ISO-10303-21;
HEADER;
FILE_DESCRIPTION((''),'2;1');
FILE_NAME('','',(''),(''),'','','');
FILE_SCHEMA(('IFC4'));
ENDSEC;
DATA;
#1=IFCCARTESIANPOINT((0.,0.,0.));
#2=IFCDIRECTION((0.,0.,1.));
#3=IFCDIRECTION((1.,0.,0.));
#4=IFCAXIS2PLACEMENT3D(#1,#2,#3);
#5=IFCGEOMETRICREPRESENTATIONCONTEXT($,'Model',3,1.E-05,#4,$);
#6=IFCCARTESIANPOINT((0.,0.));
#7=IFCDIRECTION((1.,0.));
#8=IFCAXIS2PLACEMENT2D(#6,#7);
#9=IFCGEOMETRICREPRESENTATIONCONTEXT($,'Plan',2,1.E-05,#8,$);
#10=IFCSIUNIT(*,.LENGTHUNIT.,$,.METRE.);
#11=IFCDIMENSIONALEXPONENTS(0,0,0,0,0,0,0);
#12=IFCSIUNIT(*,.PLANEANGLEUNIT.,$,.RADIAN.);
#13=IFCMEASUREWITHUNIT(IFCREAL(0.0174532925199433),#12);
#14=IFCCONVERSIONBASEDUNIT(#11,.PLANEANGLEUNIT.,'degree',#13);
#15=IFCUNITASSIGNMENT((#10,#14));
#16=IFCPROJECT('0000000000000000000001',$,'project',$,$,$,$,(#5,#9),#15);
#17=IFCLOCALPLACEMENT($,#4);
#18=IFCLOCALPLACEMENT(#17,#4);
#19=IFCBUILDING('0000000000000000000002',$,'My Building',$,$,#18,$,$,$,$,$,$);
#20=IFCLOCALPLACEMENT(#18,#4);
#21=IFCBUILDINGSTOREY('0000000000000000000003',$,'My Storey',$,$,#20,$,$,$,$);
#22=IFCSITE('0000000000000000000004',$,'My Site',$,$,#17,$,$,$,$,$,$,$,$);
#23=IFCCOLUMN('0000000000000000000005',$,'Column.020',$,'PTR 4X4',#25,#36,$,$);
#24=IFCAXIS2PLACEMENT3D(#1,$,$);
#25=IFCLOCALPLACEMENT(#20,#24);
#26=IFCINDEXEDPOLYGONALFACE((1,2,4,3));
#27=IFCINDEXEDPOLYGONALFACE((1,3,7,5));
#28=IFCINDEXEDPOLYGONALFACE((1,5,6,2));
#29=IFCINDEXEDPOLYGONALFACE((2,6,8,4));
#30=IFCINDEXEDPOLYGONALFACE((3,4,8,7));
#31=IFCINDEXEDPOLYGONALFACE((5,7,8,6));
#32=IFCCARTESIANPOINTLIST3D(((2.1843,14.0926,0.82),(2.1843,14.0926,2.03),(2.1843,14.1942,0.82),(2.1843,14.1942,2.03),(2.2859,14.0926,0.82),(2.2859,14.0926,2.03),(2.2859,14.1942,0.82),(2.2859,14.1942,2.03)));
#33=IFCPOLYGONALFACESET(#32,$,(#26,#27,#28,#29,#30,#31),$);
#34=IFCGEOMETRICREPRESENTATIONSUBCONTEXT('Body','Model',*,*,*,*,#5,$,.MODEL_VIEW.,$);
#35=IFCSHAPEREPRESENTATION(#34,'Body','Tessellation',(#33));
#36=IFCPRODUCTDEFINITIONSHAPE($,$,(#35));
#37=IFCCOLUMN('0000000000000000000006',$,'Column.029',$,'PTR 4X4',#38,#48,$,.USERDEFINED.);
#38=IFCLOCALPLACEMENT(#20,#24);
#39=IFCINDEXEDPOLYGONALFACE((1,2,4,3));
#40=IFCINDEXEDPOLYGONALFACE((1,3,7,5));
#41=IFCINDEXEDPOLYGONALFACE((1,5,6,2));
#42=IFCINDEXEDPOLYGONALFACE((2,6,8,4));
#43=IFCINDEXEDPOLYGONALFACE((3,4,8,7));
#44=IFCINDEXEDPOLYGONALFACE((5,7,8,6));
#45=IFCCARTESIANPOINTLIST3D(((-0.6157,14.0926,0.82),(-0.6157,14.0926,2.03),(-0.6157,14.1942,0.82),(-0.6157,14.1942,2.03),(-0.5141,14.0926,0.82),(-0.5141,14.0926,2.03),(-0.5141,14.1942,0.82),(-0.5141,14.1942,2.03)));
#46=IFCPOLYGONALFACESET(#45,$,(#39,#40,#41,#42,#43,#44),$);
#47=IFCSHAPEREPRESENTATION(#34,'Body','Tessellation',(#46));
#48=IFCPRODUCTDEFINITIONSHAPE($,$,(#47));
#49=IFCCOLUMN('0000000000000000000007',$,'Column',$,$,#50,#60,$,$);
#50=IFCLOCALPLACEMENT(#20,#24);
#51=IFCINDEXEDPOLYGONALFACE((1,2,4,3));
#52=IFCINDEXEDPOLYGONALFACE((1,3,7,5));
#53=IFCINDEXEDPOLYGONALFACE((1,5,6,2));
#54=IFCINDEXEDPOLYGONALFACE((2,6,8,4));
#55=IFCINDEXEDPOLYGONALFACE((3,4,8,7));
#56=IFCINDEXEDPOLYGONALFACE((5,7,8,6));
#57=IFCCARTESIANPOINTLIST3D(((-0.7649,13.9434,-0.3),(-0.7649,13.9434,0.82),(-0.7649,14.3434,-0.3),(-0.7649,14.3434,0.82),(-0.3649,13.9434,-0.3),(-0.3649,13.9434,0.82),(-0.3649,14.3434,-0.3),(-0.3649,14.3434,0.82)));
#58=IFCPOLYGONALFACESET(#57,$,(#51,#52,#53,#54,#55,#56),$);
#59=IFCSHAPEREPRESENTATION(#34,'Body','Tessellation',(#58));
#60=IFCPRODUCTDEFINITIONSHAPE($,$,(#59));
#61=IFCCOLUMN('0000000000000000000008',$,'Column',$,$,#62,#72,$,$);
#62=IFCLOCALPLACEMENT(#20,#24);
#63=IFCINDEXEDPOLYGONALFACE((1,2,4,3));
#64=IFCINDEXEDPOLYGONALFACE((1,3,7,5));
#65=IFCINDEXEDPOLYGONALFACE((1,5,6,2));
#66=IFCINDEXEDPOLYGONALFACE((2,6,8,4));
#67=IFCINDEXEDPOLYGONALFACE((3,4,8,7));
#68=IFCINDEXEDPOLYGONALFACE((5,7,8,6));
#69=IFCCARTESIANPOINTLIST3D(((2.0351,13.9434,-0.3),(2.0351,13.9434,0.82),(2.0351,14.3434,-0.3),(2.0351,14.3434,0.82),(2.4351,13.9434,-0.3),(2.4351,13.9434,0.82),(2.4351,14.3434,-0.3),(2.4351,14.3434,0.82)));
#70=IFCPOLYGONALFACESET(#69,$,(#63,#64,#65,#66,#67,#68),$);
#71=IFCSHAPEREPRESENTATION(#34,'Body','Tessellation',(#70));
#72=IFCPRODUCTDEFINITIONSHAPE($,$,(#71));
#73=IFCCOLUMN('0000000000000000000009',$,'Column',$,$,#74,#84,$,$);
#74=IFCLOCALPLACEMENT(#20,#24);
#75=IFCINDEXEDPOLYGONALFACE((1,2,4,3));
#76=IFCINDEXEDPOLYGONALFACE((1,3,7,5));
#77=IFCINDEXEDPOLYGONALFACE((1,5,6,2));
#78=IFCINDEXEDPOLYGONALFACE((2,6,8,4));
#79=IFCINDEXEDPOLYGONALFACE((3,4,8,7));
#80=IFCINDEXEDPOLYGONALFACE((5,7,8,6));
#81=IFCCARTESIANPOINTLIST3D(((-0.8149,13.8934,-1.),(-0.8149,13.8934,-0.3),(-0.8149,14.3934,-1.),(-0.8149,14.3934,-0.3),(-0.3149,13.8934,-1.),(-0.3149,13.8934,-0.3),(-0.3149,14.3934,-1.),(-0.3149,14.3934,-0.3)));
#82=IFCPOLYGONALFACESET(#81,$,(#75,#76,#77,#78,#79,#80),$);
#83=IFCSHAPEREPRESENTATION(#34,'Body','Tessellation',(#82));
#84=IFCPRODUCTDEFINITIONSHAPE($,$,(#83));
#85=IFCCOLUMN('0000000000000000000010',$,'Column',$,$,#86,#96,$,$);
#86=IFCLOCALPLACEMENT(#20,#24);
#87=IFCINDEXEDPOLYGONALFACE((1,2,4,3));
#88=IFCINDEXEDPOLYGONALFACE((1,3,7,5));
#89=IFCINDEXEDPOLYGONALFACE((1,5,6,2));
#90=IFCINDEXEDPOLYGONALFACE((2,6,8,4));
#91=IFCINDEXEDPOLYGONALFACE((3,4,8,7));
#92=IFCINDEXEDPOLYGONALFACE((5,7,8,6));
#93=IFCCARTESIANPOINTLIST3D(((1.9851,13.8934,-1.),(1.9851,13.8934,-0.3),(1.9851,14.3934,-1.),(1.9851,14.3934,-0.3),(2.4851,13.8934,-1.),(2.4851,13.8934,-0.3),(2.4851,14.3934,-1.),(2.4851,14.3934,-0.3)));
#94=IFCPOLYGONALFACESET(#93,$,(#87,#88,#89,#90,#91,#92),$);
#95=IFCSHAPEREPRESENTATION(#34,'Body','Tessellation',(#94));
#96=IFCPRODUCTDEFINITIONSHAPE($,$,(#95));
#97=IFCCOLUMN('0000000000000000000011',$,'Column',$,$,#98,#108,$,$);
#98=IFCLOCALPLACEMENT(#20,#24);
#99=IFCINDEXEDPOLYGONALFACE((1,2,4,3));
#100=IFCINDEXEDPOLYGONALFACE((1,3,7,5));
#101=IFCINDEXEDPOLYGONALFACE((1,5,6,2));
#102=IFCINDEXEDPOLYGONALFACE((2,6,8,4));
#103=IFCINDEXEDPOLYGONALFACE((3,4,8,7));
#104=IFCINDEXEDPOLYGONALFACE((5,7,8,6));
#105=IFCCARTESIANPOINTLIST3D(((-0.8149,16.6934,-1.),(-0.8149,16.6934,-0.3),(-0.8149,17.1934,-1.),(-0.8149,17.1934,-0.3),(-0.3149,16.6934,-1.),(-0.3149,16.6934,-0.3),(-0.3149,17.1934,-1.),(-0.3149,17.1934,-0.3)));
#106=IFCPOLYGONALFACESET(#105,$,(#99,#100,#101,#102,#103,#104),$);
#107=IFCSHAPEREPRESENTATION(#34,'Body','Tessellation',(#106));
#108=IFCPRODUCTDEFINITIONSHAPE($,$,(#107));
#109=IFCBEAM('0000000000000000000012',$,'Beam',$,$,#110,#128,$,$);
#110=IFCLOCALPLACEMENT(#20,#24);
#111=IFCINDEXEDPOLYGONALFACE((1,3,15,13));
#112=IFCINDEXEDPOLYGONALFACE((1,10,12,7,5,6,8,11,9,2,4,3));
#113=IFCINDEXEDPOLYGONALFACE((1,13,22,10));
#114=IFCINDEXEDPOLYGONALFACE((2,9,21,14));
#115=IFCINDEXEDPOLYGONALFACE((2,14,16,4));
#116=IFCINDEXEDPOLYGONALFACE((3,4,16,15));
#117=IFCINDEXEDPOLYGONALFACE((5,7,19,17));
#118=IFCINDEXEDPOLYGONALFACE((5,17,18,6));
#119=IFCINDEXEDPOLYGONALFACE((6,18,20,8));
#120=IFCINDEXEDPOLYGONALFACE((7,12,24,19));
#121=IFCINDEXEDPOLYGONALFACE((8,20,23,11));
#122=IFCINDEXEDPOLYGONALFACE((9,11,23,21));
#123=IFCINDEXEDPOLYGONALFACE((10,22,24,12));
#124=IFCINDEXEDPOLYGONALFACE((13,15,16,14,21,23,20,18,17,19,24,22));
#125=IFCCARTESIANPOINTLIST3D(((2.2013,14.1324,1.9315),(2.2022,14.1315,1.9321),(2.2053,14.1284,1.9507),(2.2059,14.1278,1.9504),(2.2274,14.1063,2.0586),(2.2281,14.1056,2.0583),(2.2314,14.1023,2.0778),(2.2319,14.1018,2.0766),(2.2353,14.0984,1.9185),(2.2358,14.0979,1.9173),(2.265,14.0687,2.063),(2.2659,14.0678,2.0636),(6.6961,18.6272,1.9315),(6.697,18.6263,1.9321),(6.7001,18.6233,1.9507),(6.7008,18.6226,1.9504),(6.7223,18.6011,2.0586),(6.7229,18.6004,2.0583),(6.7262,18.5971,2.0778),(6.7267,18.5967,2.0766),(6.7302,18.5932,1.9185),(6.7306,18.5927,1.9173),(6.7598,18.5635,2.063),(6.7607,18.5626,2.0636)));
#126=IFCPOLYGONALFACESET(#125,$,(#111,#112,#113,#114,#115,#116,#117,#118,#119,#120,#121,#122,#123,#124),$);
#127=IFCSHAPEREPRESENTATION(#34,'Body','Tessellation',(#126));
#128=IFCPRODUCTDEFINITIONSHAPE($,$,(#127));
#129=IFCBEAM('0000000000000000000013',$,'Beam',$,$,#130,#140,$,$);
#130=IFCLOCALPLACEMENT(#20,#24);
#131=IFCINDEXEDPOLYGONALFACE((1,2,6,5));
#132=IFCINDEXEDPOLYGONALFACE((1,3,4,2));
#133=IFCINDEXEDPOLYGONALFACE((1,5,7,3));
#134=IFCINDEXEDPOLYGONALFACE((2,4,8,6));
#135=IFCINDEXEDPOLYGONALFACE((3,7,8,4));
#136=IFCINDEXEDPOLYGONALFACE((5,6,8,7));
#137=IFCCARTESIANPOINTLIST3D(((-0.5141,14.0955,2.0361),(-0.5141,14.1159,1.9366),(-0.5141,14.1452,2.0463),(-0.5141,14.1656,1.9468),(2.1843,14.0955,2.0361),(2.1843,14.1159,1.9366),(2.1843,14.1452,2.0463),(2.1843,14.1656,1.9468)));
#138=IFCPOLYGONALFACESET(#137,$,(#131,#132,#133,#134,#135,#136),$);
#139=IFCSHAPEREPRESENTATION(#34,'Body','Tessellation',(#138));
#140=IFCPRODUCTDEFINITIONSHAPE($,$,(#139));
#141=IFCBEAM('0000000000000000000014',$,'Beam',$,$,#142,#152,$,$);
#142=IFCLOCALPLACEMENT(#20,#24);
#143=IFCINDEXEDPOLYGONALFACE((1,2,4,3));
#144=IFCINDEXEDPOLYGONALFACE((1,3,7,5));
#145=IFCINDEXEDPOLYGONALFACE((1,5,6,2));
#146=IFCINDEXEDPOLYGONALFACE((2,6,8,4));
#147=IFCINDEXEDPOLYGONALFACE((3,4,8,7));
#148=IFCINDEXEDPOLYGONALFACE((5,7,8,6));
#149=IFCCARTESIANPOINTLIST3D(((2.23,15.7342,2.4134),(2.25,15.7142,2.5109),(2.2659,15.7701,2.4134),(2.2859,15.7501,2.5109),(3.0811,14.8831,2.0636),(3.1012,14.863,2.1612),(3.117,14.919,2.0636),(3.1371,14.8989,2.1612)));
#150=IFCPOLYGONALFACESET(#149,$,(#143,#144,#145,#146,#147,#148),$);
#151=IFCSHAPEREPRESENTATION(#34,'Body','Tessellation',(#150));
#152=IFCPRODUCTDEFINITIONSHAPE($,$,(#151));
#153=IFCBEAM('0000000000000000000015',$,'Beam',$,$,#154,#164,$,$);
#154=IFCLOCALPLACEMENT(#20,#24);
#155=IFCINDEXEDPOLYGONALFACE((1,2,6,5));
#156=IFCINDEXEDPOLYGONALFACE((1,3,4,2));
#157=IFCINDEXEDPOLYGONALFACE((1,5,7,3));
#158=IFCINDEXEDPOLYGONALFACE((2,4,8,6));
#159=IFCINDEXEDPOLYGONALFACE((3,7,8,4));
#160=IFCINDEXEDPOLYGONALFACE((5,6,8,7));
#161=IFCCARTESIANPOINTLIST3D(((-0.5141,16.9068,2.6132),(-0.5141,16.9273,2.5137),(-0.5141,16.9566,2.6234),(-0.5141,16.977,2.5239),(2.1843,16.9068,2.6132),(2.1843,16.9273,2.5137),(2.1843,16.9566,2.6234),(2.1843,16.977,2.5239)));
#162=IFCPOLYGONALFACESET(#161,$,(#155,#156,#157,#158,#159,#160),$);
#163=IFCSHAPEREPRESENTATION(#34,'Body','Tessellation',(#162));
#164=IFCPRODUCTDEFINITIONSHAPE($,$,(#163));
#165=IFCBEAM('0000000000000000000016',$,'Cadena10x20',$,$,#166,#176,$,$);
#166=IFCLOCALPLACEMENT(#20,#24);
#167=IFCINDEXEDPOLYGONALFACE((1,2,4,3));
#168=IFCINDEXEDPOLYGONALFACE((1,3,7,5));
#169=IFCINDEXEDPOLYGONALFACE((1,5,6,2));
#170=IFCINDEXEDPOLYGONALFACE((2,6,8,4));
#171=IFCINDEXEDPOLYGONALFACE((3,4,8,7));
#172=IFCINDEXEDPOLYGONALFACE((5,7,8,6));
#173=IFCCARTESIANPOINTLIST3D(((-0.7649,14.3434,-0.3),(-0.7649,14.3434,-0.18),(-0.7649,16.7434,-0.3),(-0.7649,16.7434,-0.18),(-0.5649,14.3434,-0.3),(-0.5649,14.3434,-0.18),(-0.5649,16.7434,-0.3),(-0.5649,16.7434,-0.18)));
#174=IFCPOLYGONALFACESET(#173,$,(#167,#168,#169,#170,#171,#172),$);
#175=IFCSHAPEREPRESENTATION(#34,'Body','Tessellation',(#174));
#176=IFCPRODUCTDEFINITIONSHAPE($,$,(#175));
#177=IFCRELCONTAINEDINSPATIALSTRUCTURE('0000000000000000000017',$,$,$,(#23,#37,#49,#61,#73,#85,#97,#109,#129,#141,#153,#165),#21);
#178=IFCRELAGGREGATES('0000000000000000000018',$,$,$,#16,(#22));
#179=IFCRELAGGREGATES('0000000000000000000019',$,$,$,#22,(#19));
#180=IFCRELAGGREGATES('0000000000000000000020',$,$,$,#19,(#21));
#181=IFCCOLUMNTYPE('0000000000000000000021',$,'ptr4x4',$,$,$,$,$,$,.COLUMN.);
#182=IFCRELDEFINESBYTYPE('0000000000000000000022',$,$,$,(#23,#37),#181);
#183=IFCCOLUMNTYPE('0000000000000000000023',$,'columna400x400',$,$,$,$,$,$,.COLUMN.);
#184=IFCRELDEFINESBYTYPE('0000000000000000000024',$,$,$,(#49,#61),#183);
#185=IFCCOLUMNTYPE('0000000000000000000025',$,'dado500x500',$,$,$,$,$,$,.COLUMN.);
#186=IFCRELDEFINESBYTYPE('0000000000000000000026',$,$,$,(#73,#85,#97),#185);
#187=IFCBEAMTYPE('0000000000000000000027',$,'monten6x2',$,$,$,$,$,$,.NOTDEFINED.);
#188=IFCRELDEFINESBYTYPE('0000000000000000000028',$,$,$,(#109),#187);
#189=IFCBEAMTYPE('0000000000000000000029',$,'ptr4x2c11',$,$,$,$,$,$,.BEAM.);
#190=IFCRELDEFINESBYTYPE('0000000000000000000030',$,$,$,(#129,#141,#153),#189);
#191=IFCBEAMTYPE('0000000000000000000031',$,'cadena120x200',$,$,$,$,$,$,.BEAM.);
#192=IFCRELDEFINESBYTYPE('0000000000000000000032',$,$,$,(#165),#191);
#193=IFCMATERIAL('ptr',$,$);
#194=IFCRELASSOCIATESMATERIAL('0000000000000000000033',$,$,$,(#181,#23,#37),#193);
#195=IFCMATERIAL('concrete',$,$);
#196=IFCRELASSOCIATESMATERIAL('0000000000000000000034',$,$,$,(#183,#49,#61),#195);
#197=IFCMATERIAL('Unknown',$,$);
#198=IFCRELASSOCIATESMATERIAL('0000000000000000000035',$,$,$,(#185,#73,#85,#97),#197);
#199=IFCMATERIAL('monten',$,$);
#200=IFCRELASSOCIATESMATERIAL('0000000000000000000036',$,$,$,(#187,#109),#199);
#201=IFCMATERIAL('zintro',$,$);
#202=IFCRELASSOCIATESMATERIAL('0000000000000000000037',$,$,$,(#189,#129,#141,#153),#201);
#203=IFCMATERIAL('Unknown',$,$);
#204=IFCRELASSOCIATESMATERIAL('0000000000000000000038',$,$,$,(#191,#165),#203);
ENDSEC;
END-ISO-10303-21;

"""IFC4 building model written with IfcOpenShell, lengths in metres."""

from ifc_helpers import new_model, entity, si_unit, converted_unit, frame, origin_with_axes, origin_2d_with_axis, place, context, subcontext, project, spatial, rectangle, c_section, extrude, material, material_profile, profile_set, profile_usage, type_object, element, save


model = new_model("IFC4")

# Units and contexts
model_context = context("Model", 3, precision=1e-05, world=origin_with_axes())
plan_context = context("Plan", 2, precision=1e-05, world=origin_2d_with_axis())
body_context = subcontext(model_context, "Body", "Model", "MODEL_VIEW")
ifc_project = project(units=[si_unit("LENGTHUNIT", "METRE"), converted_unit("PLANEANGLEUNIT", "degree", entity("IfcReal", 0.0174532925199433), si_unit("PLANEANGLEUNIT", "RADIAN"), dimensions=[0, 0, 0, 0, 0, 0, 0])], contexts=[model_context, plan_context])

# Site, building, storey
site_placement = place(None, origin_with_axes())
site = spatial("IfcSite", under=ifc_project, at=site_placement, Name="My Site")
building_placement = place(site_placement, origin_with_axes())
building = spatial("IfcBuilding", under=site, at=building_placement, Name="My Building")
storey_placement = place(building_placement, origin_with_axes())
storey = spatial("IfcBuildingStorey", under=building, at=storey_placement, Name="My Storey")

# Columns
ifc_material_1 = material(Name="ptr")
ifc_material_profile_1 = material_profile(ifc_material_1, rectangle(XDim=0.1016, YDim=0.1016))
ifc_profile_set_1 = profile_set([ifc_material_profile_1])
ifc_profile_usage_1 = profile_usage(ifc_profile_set_1, cardinal=5)
column_type_1 = type_object("IfcColumnType", Name="ptr4x4", PredefinedType="COLUMN", material=ifc_profile_set_1)
column_1_placement = place(storey_placement, frame((2.2351, 14.1434, 0.82), z_axis=(0.0, 0.0, 1.0), x_axis=(1.0, 0.0, 0.0)))
element("IfcColumn", 1, at=column_1_placement, inside=storey, type_object=column_type_1, material=ifc_profile_usage_1, Name="Column.020", ObjectType="PTR 4X4", context=body_context, shape_type="SweptSolid", body=[
    extrude(rectangle(XDim=0.1016, YDim=0.1016), origin_with_axes(), (0.0, 0.0, 1.0), 1.21),
])
ifc_profile_usage_2 = profile_usage(ifc_profile_set_1, cardinal=5)
column_2_placement = place(storey_placement, frame((-0.5649, 14.1434, 0.82), z_axis=(0.0, 0.0, 1.0), x_axis=(1.0, 0.0, 0.0)))
element("IfcColumn", 2, at=column_2_placement, inside=storey, type_object=column_type_1, material=ifc_profile_usage_2, Name="Column.029", ObjectType="PTR 4X4", PredefinedType="USERDEFINED", context=body_context, shape_type="SweptSolid", body=[
    extrude(rectangle(XDim=0.1016, YDim=0.1016), origin_with_axes(), (0.0, 0.0, 1.0), 1.21),
])
ifc_material_2 = material(Name="concrete")
ifc_material_profile_2 = material_profile(ifc_material_2, rectangle(XDim=0.4, YDim=0.4))
ifc_profile_set_2 = profile_set([ifc_material_profile_2], Name="concrete")
ifc_profile_usage_3 = profile_usage(ifc_profile_set_2)
column_type_2 = type_object("IfcColumnType", Name="columna400x400", PredefinedType="COLUMN", material=ifc_profile_set_2)
column_3_placement = place(storey_placement, frame((-0.5649, 14.1434, -0.3), z_axis=(0.0, 0.0, 1.0), x_axis=(1.0, 0.0, 0.0)))
element("IfcColumn", 3, at=column_3_placement, inside=storey, type_object=column_type_2, material=ifc_profile_usage_3, Name="Column", context=body_context, shape_type="SweptSolid", body=[
    extrude(rectangle(XDim=0.4, YDim=0.4), origin_with_axes(), (0.0, 0.0, 1.0), 1.12),
])
ifc_profile_usage_4 = profile_usage(ifc_profile_set_2)
column_4_placement = place(storey_placement, frame((2.2351, 14.1434, -0.3), z_axis=(0.0, 0.0, 1.0), x_axis=(1.0, 0.0, 0.0)))
element("IfcColumn", 4, at=column_4_placement, inside=storey, type_object=column_type_2, material=ifc_profile_usage_4, Name="Column", context=body_context, shape_type="SweptSolid", body=[
    extrude(rectangle(XDim=0.4, YDim=0.4), origin_with_axes(), (0.0, 0.0, 1.0), 1.12),
])
ifc_material_3 = material(Name="Unknown")
ifc_material_profile_3 = material_profile(ifc_material_3, rectangle(XDim=0.5, YDim=0.5))
ifc_profile_set_3 = profile_set([ifc_material_profile_3], Name="concrete")
ifc_profile_usage_5 = profile_usage(ifc_profile_set_3)
column_type_3 = type_object("IfcColumnType", Name="dado500x500", PredefinedType="COLUMN", material=ifc_profile_set_3)
column_5_placement = place(storey_placement, frame((-0.5649, 14.1434, -1.0), z_axis=(0.0, 0.0, 1.0), x_axis=(1.0, 0.0, 0.0)))
element("IfcColumn", 5, at=column_5_placement, inside=storey, type_object=column_type_3, material=ifc_profile_usage_5, Name="Column", context=body_context, shape_type="SweptSolid", body=[
    extrude(rectangle(XDim=0.5, YDim=0.5), origin_with_axes(), (0.0, 0.0, 1.0), 0.7),
])
ifc_profile_usage_6 = profile_usage(ifc_profile_set_3)
column_6_placement = place(storey_placement, frame((2.2351, 14.1434, -1.0), z_axis=(0.0, 0.0, 1.0), x_axis=(1.0, 0.0, 0.0)))
element("IfcColumn", 6, at=column_6_placement, inside=storey, type_object=column_type_3, material=ifc_profile_usage_6, Name="Column", context=body_context, shape_type="SweptSolid", body=[
    extrude(rectangle(XDim=0.5, YDim=0.5), origin_with_axes(), (0.0, 0.0, 1.0), 0.7),
])
ifc_profile_usage_7 = profile_usage(ifc_profile_set_3)
column_7_placement = place(storey_placement, frame((-0.5649, 16.9434, -1.0), z_axis=(0.0, 0.0, 1.0), x_axis=(1.0, 0.0, 0.0)))
element("IfcColumn", 7, at=column_7_placement, inside=storey, type_object=column_type_3, material=ifc_profile_usage_7, Name="Column", context=body_context, shape_type="SweptSolid", body=[
    extrude(rectangle(XDim=0.5, YDim=0.5), origin_with_axes(), (0.0, 0.0, 1.0), 0.7),
])

# Beams
ifc_material_4 = material(Name="monten")
ifc_material_profile_4 = material_profile(ifc_material_4, c_section(Depth=0.1524, Width=0.0508, WallThickness=0.001, Girth=0.02))
ifc_profile_set_4 = profile_set([ifc_material_profile_4])
ifc_profile_usage_8 = profile_usage(ifc_profile_set_4, cardinal=5)
beam_type_1 = type_object("IfcBeamType", Name="monten6x2", PredefinedType="NOTDEFINED", material=ifc_profile_set_4)
beam_1_placement = place(storey_placement, frame((2.2336, 14.1001, 1.9976), z_axis=(0.707107, 0.707107, 0.0), x_axis=(-0.67903, 0.67903, 0.278991)))
element("IfcBeam", 8, at=beam_1_placement, inside=storey, type_object=beam_type_1, material=ifc_profile_usage_8, Name="Beam", context=body_context, shape_type="SweptSolid", body=[
    extrude(c_section(Depth=0.1524, Width=0.0508, WallThickness=0.001, Girth=0.02), origin_with_axes(), (0.0, 0.0, 1.0), 6.3566),
])
ifc_material_5 = material(Name="zintro")
ifc_material_profile_5 = material_profile(ifc_material_5, rectangle(XDim=0.0508, YDim=0.1016))
ifc_profile_set_5 = profile_set([ifc_material_profile_5])
ifc_profile_usage_9 = profile_usage(ifc_profile_set_5)
beam_type_2 = type_object("IfcBeamType", Name="ptr4x2c11", PredefinedType="BEAM", material=ifc_profile_set_5)
beam_2_placement = place(storey_placement, frame((-0.5141, 14.1306, 1.9914), z_axis=(1.0, 0.0, 0.0), x_axis=(0.0, 0.979575, 0.201078)))
element("IfcBeam", 9, at=beam_2_placement, inside=storey, type_object=beam_type_2, material=ifc_profile_usage_9, Name="Beam", context=body_context, shape_type="SweptSolid", body=[
    extrude(rectangle(XDim=0.0508, YDim=0.1016), origin_with_axes(), (0.0, 0.0, 1.0), 2.6984),
])
ifc_profile_usage_10 = profile_usage(ifc_profile_set_5)
beam_3_placement = place(storey_placement, frame((2.2579, 15.7422, 2.4621), z_axis=(0.67903, -0.67903, -0.278991), x_axis=(0.707107, 0.707107, 0.0)))
element("IfcBeam", 10, at=beam_3_placement, inside=storey, type_object=beam_type_2, material=ifc_profile_usage_10, Name="Beam", context=body_context, shape_type="SweptSolid", body=[
    extrude(rectangle(XDim=0.0508, YDim=0.1016), origin_with_axes(), (0.0, 0.0, 1.0), 1.2535),
])
ifc_profile_usage_11 = profile_usage(ifc_profile_set_5)
beam_4_placement = place(storey_placement, frame((-0.5141, 16.9419, 2.5685), z_axis=(1.0, 0.0, 0.0), x_axis=(0.0, 0.979575, 0.201078)))
element("IfcBeam", 11, at=beam_4_placement, inside=storey, type_object=beam_type_2, material=ifc_profile_usage_11, Name="Beam", context=body_context, shape_type="SweptSolid", body=[
    extrude(rectangle(XDim=0.0508, YDim=0.1016), origin_with_axes(), (0.0, 0.0, 1.0), 2.6984),
])
ifc_material_6 = material(Name="Unknown")
ifc_material_profile_6 = material_profile(ifc_material_6, rectangle(XDim=0.2, YDim=0.12))
ifc_profile_set_6 = profile_set([ifc_material_profile_6], Name="concrete")
ifc_profile_usage_12 = profile_usage(ifc_profile_set_6, cardinal=5)
beam_type_3 = type_object("IfcBeamType", Name="cadena120x200", PredefinedType="BEAM", material=ifc_profile_set_6)
beam_5_placement = place(storey_placement, frame((-0.6649, 16.7434, -0.24), z_axis=(0.0, -1.0, 0.0), x_axis=(1.0, 0.0, 0.0)))
element("IfcBeam", 12, at=beam_5_placement, inside=storey, type_object=beam_type_3, material=ifc_profile_usage_12, Name="Cadena10x20", context=body_context, shape_type="SweptSolid", body=[
    extrude(rectangle(XDim=0.2, YDim=0.12), origin_with_axes(), (0.0, 0.0, 1.0), 2.4),
])

save(model, "model.ifc")
